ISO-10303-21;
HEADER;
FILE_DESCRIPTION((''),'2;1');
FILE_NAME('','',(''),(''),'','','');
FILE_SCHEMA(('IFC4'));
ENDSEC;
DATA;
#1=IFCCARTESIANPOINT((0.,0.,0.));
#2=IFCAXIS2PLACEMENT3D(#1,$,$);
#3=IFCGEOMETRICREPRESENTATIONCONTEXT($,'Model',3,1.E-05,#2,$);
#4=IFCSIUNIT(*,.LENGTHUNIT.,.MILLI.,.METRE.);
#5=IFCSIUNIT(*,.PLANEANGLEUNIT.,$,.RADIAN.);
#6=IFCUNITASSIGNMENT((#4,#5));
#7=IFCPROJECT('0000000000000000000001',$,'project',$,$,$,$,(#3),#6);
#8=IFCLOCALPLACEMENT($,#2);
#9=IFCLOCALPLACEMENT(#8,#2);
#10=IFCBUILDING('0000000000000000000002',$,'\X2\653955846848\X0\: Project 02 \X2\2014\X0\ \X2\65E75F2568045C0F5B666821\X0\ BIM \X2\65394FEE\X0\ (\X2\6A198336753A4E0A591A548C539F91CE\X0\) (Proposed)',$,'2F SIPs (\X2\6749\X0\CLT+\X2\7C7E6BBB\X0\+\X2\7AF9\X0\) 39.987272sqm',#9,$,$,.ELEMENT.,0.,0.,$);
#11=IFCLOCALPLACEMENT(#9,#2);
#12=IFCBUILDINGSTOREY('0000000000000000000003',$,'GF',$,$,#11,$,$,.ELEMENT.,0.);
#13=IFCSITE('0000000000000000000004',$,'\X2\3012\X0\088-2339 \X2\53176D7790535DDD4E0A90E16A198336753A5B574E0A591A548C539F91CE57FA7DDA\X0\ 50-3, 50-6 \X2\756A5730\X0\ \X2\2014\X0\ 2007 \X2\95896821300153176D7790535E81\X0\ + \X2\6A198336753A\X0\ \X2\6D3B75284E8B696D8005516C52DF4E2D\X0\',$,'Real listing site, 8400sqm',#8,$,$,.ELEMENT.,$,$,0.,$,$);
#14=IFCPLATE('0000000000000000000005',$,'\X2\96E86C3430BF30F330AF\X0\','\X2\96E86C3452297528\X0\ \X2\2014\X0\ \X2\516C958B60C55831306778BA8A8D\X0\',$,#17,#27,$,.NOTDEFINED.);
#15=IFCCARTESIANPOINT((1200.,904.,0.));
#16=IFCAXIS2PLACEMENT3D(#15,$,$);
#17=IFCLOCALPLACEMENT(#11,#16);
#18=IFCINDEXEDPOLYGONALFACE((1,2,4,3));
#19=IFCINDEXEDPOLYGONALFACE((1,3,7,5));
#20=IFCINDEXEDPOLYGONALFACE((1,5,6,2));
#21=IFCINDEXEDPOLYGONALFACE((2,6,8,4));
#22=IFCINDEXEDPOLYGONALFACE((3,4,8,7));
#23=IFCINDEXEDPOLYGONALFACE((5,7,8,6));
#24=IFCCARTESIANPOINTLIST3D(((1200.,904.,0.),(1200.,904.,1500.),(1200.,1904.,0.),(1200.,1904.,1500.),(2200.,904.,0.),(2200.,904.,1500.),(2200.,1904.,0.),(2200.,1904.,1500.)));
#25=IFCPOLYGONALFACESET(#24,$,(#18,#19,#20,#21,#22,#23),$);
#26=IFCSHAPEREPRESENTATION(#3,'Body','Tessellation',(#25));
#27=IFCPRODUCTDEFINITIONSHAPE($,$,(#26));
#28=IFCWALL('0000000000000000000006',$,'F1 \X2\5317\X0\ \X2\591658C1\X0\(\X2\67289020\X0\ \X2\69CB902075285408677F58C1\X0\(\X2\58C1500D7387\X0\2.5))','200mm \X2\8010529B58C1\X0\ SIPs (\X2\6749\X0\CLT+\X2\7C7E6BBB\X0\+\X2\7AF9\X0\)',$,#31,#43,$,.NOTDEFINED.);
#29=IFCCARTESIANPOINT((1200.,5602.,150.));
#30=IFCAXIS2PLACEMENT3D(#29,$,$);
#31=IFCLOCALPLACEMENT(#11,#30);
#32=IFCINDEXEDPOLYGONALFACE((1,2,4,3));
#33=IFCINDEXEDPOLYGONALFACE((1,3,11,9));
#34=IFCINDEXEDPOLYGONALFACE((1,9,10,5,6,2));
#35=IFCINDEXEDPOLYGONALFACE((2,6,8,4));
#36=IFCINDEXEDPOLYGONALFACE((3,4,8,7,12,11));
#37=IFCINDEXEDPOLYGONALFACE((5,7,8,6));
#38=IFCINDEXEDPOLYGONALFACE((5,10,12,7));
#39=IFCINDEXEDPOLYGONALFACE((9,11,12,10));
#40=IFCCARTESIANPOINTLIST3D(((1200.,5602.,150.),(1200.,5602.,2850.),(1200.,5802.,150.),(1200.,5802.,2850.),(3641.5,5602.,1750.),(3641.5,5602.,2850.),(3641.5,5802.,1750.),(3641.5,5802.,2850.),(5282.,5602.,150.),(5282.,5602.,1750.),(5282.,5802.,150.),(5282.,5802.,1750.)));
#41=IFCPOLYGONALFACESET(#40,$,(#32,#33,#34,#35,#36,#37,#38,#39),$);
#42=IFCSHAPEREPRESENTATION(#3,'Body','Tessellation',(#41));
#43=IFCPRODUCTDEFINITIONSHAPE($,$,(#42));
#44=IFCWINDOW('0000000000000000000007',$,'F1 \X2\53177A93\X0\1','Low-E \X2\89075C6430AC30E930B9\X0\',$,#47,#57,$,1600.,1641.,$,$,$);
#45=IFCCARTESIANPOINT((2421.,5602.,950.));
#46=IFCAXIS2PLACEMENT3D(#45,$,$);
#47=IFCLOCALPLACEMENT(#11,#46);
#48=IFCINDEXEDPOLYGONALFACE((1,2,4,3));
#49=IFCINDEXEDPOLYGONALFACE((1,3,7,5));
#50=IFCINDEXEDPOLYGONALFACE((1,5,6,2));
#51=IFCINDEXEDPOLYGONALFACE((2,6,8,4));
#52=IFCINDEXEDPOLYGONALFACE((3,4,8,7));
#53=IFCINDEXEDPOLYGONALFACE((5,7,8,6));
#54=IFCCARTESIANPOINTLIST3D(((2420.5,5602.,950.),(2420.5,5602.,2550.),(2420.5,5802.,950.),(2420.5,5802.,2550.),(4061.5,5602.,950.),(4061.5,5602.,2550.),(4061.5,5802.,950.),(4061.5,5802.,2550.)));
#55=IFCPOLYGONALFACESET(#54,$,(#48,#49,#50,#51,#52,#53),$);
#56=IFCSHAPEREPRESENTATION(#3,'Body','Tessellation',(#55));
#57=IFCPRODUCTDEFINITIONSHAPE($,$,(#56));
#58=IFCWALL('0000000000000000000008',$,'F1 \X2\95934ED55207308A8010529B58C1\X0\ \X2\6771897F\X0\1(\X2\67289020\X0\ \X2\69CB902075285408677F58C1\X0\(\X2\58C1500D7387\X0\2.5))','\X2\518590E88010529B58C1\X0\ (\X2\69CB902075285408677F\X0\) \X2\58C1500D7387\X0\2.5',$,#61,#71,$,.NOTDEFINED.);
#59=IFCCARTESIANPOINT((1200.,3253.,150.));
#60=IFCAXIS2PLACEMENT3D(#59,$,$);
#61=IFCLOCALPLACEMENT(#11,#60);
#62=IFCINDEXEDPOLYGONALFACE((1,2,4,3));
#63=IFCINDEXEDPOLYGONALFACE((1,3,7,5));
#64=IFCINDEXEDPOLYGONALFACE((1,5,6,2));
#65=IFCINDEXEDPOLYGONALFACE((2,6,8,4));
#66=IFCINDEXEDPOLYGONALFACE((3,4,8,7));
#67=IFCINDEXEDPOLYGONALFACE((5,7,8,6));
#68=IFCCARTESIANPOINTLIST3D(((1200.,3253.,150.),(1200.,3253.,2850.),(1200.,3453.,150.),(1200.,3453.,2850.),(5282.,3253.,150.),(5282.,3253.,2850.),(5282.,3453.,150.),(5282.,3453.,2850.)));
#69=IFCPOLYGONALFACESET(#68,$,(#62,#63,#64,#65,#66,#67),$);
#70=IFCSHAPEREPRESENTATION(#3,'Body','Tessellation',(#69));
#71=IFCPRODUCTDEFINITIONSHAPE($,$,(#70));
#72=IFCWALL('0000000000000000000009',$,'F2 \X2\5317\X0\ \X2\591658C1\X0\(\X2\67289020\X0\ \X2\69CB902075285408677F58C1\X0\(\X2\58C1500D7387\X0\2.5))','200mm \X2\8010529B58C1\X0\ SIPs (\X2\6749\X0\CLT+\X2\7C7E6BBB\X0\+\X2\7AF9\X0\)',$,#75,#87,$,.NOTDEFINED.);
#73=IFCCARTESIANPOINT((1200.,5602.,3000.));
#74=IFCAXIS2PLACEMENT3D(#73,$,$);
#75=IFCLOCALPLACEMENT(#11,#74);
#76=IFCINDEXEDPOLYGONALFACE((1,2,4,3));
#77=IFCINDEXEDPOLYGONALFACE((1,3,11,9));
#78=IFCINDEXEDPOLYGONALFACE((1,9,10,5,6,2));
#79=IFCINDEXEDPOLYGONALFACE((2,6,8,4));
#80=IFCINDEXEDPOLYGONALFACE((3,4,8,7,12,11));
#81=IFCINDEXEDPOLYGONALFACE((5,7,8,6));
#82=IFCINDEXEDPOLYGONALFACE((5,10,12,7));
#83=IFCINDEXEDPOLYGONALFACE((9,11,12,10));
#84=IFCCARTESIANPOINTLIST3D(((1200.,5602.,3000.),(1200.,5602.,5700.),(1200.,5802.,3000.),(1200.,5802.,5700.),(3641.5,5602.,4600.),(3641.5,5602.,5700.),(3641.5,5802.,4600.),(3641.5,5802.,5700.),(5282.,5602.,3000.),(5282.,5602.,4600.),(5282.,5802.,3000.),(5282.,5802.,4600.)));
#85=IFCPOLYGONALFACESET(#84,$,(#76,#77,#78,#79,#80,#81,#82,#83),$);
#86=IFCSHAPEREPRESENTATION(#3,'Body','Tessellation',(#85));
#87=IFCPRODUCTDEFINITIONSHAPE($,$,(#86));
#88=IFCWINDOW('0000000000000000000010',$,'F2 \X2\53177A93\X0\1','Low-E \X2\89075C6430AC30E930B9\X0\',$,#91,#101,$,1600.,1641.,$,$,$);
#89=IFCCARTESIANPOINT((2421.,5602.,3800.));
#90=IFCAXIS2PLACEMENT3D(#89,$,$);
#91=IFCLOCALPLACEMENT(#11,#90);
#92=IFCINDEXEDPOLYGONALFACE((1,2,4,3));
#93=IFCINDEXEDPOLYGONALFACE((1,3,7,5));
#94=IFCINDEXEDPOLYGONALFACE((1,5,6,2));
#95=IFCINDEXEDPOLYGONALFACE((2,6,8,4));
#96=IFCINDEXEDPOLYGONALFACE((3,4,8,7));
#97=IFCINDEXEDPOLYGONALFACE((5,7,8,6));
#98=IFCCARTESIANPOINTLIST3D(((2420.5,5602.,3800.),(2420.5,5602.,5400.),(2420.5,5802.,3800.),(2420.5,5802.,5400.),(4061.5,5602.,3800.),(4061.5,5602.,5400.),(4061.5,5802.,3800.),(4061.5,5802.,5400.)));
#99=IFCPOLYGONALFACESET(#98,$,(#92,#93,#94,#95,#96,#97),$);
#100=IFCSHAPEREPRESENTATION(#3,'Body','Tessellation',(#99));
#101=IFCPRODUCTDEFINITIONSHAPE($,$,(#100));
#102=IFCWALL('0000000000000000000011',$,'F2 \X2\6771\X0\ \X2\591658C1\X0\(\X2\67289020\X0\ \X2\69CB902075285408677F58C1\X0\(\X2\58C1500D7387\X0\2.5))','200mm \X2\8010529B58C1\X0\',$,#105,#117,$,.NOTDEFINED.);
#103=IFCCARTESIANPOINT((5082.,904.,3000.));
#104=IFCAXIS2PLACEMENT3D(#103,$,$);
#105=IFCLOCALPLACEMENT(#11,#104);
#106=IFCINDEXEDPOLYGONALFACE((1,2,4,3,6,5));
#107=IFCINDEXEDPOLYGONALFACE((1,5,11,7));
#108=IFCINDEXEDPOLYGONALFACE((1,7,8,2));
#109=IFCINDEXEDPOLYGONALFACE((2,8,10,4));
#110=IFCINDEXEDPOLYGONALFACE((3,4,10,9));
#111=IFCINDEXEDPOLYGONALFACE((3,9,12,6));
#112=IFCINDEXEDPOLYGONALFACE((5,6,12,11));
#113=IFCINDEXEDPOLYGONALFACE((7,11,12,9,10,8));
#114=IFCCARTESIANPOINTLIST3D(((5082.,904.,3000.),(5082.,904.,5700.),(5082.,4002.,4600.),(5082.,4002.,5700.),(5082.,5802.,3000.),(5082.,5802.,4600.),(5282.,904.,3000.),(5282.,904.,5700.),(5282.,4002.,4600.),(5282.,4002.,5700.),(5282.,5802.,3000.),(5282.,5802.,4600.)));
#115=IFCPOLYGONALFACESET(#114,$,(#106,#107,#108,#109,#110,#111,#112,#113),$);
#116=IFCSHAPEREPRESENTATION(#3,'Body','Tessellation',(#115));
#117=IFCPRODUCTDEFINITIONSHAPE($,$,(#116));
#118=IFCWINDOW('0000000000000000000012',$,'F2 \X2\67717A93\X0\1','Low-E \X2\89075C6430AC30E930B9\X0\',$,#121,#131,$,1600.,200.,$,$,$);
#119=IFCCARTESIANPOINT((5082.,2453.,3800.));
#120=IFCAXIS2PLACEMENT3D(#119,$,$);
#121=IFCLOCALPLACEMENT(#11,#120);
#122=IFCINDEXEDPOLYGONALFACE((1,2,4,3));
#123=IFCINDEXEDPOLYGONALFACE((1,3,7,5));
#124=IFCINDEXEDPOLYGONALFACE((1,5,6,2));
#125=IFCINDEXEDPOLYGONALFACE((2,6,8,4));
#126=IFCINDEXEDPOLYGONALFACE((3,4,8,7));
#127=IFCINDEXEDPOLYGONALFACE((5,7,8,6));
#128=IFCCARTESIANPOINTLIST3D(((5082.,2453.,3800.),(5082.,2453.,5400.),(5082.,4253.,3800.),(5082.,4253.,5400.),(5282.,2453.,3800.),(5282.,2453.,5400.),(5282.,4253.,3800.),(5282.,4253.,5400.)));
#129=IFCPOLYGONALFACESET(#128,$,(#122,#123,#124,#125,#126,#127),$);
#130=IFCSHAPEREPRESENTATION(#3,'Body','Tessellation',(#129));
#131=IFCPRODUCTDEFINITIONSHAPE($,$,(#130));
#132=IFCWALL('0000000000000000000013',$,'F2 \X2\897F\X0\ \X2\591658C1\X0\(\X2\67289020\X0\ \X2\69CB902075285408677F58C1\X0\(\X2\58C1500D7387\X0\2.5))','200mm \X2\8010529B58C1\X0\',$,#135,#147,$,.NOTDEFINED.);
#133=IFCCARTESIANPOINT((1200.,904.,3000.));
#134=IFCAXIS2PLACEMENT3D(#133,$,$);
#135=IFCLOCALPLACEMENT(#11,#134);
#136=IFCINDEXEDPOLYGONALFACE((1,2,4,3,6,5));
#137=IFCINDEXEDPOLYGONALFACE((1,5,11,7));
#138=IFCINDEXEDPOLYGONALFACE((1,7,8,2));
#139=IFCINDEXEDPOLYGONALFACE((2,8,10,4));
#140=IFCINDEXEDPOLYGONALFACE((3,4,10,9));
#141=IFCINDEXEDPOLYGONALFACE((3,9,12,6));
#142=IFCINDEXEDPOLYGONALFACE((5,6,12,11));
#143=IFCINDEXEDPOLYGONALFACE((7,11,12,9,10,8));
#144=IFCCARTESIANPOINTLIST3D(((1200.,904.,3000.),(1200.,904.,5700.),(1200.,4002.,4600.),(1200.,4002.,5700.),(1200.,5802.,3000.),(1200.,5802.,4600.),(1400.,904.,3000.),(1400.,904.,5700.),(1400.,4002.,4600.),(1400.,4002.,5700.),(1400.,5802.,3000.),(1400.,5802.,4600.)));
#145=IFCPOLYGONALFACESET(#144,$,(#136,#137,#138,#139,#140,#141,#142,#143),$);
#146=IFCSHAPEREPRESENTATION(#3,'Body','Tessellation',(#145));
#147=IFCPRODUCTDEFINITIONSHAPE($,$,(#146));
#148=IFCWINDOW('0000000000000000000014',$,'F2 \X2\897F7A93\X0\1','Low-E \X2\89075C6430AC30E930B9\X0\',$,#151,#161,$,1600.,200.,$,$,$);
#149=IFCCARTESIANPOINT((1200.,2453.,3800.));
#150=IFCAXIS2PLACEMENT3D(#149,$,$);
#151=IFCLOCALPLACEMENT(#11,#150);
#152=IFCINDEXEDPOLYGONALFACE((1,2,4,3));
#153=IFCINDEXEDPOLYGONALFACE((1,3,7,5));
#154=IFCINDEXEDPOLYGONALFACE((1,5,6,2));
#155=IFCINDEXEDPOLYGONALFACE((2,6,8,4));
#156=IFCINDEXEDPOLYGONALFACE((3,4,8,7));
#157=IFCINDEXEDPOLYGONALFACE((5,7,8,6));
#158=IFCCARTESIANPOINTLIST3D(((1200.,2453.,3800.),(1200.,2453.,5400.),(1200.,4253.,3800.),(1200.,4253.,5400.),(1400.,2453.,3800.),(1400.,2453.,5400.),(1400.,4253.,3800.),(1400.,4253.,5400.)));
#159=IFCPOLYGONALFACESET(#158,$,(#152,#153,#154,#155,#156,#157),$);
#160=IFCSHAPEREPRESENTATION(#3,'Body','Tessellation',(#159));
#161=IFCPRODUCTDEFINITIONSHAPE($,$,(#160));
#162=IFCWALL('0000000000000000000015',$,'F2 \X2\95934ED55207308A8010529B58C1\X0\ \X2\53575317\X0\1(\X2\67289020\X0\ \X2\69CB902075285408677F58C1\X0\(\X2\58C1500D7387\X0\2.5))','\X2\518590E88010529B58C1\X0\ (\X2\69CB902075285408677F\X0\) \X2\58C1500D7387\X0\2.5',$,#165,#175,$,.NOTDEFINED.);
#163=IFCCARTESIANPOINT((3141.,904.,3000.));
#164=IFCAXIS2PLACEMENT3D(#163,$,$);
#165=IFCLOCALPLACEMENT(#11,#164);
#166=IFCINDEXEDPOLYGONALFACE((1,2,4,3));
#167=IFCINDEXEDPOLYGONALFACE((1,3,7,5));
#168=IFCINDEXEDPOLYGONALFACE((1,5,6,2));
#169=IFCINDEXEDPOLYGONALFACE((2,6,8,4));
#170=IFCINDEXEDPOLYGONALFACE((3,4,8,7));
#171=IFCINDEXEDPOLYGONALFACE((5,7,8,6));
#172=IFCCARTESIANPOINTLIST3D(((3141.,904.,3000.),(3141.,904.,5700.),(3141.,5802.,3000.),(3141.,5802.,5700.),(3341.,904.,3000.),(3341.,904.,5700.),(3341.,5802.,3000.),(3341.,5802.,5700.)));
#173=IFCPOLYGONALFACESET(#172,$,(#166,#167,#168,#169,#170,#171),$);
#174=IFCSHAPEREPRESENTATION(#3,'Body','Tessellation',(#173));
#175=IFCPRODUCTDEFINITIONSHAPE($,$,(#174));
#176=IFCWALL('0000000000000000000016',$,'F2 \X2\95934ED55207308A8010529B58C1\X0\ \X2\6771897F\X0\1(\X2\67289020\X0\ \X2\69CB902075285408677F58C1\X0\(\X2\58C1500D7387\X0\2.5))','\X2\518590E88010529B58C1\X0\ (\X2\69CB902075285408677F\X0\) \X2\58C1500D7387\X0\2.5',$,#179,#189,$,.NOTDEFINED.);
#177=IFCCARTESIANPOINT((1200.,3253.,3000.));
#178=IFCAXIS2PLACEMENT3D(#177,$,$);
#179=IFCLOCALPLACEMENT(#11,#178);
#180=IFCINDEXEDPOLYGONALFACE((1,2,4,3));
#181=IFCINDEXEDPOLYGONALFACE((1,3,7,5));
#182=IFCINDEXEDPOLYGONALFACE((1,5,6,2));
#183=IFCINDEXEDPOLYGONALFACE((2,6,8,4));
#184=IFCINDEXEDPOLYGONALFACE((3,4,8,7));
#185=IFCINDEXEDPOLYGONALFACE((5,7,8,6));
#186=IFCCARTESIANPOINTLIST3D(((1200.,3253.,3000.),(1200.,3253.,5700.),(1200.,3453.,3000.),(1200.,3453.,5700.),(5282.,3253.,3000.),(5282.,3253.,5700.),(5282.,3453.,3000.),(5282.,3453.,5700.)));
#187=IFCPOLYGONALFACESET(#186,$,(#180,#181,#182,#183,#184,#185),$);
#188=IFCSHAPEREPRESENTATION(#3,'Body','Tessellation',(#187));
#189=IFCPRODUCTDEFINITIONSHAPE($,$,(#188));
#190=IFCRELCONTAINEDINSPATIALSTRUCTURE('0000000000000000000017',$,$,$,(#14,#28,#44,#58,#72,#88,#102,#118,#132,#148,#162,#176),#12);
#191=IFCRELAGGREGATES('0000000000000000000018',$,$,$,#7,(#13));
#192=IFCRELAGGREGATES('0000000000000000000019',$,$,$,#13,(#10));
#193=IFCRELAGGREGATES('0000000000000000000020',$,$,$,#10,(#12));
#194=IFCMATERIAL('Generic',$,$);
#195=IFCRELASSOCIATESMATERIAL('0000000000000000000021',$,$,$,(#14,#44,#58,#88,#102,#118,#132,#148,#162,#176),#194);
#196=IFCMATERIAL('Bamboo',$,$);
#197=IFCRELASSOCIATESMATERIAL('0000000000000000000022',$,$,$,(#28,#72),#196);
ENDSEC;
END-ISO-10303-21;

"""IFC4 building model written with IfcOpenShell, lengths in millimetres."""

from ifc_helpers import new_model, si_unit, frame, frame_2d, origin, place, context, project, spatial, rectangle, extrude, material, element, fill, save


model = new_model("IFC4")

# Units and contexts
model_context = context("Model", 3, precision=1e-05, world=origin())
ifc_project = project(units=[si_unit("LENGTHUNIT", "METRE", prefix="MILLI"), si_unit("PLANEANGLEUNIT", "RADIAN")], contexts=[model_context])

# Site, building, storey
site_placement = place(None, origin())
site = spatial("IfcSite", under=ifc_project, at=site_placement, Name="〒088-2339 北海道川上郡標茶町字上多和原野基線 50-3, 50-6 番地 — 2007 閉校、北海道庁 + 標茶町 活用事業者公募中", ObjectType="Real listing site, 8400sqm", CompositionType="ELEMENT", RefElevation=0.0)
building_placement = place(site_placement, origin())
building = spatial("IfcBuilding", under=site, at=building_placement, Name="改善案: Project 02 — 旧弥栄小学校 BIM 改修 (標茶町上多和原野) (Proposed)", ObjectType="2F SIPs (杉CLT+籾殻+竹) 39.987272sqm", CompositionType="ELEMENT", ElevationOfRefHeight=0.0, ElevationOfTerrain=0.0)
storey_placement = place(building_placement, origin())
storey = spatial("IfcBuildingStorey", under=building, at=storey_placement, Name="GF", CompositionType="ELEMENT", Elevation=0.0)

# Plate
ifc_material_1 = material(Name="Generic")
plate_placement = place(storey_placement, frame((1200.0, 904.0, 0.0)))
element("IfcPlate", 1, at=plate_placement, inside=storey, material=ifc_material_1, Name="雨水タンク", Description="雨水利用 — 公開情報で確認", PredefinedType="NOTDEFINED", context=model_context, shape_type="SweptSolid", body=[
    extrude(rectangle(XDim=1000.0, YDim=1000.0, at=frame_2d((500.0, 500.0))), frame((1200.0, 904.0, 0.0)), (0.0, 0.0, 1.0), 1500.0),
])

# Wall, opening, window
ifc_material_2 = material(Name="Bamboo")
wall_1_placement = place(storey_placement, frame((1200.0, 5602.0, 150.0)))
wall_1 = element("IfcWall", 2, at=wall_1_placement, inside=storey, material=ifc_material_2, Name="F1 北 外壁(木造 構造用合板壁(壁倍率2.5))", Description="200mm 耐力壁 SIPs (杉CLT+籾殻+竹)", PredefinedType="NOTDEFINED", context=model_context, shape_type="SweptSolid", body=[
    extrude(rectangle(XDim=4082.0, YDim=200.0, at=frame_2d((2041.0, 100.0))), frame((1200.0, 5602.0, 150.0)), (0.0, 0.0, 1.0), 2700.0),
])
opening_1_placement = place(storey_placement, frame((2421.0, 5602.0, 950.0)))
opening_1 = element("IfcOpeningElement", 3, at=opening_1_placement, cuts=wall_1, PredefinedType="NOTDEFINED", context=model_context, shape_type="SweptSolid", body=[
    extrude(rectangle(XDim=1641.0, YDim=200.0, at=frame_2d((820.0, 100.0))), frame((2421.0, 5602.0, 950.0)), (0.0, 0.0, 1.0), 1600.0),
])
window_1_placement = place(storey_placement, frame((2421.0, 5602.0, 950.0)))
window_1 = element("IfcWindow", 4, at=window_1_placement, inside=storey, material=ifc_material_1, Name="F1 北窓1", Description="Low-E 複層ガラス", OverallHeight=1600.0, OverallWidth=1641.0, context=model_context, shape_type="SweptSolid", body=[
    extrude(rectangle(XDim=1641.0, YDim=200.0, at=frame_2d((820.0, 100.0))), frame((2421.0, 5602.0, 950.0)), (0.0, 0.0, 1.0), 1600.0),
])
fill(opening_1, window_1)

# Wall
wall_2_placement = place(storey_placement, frame((1200.0, 3253.0, 150.0)))
element("IfcWall", 5, at=wall_2_placement, inside=storey, material=ifc_material_1, Name="F1 間仕切り耐力壁 東西1(木造 構造用合板壁(壁倍率2.5))", Description="内部耐力壁 (構造用合板) 壁倍率2.5", PredefinedType="NOTDEFINED", context=model_context, shape_type="SweptSolid", body=[
    extrude(rectangle(XDim=4082.0, YDim=200.0, at=frame_2d((2041.0, 100.0))), frame((1200.0, 3253.0, 150.0)), (0.0, 0.0, 1.0), 2700.0),
])

# Walls, openings, windows
wall_3_placement = place(storey_placement, frame((1200.0, 5602.0, 3000.0)))
wall_3 = element("IfcWall", 6, at=wall_3_placement, inside=storey, material=ifc_material_2, Name="F2 北 外壁(木造 構造用合板壁(壁倍率2.5))", Description="200mm 耐力壁 SIPs (杉CLT+籾殻+竹)", PredefinedType="NOTDEFINED", context=model_context, shape_type="SweptSolid", body=[
    extrude(rectangle(XDim=4082.0, YDim=200.0, at=frame_2d((2041.0, 100.0))), frame((1200.0, 5602.0, 3000.0)), (0.0, 0.0, 1.0), 2700.0),
])
opening_2_placement = place(storey_placement, frame((2421.0, 5602.0, 3800.0)))
opening_2 = element("IfcOpeningElement", 7, at=opening_2_placement, cuts=wall_3, PredefinedType="NOTDEFINED", context=model_context, shape_type="SweptSolid", body=[
    extrude(rectangle(XDim=1641.0, YDim=200.0, at=frame_2d((820.0, 100.0))), frame((2421.0, 5602.0, 3800.0)), (0.0, 0.0, 1.0), 1600.0),
])
window_2_placement = place(storey_placement, frame((2421.0, 5602.0, 3800.0)))
window_2 = element("IfcWindow", 8, at=window_2_placement, inside=storey, material=ifc_material_1, Name="F2 北窓1", Description="Low-E 複層ガラス", OverallHeight=1600.0, OverallWidth=1641.0, context=model_context, shape_type="SweptSolid", body=[
    extrude(rectangle(XDim=1641.0, YDim=200.0, at=frame_2d((820.0, 100.0))), frame((2421.0, 5602.0, 3800.0)), (0.0, 0.0, 1.0), 1600.0),
])
fill(opening_2, window_2)
wall_4_placement = place(storey_placement, frame((5082.0, 904.0, 3000.0)))
wall_4 = element("IfcWall", 9, at=wall_4_placement, inside=storey, material=ifc_material_1, Name="F2 東 外壁(木造 構造用合板壁(壁倍率2.5))", Description="200mm 耐力壁", PredefinedType="NOTDEFINED", context=model_context, shape_type="SweptSolid", body=[
    extrude(rectangle(XDim=200.0, YDim=4898.0, at=frame_2d((100.0, 2449.0))), frame((5082.0, 904.0, 3000.0)), (0.0, 0.0, 1.0), 2700.0),
])
opening_3_placement = place(storey_placement, frame((5082.0, 2453.0, 3800.0)))
opening_3 = element("IfcOpeningElement", 10, at=opening_3_placement, cuts=wall_4, PredefinedType="NOTDEFINED", context=model_context, shape_type="SweptSolid", body=[
    extrude(rectangle(XDim=200.0, YDim=1800.0, at=frame_2d((100.0, 900.0))), frame((5082.0, 2453.0, 3800.0)), (0.0, 0.0, 1.0), 1600.0),
])
window_3_placement = place(storey_placement, frame((5082.0, 2453.0, 3800.0)))
window_3 = element("IfcWindow", 11, at=window_3_placement, inside=storey, material=ifc_material_1, Name="F2 東窓1", Description="Low-E 複層ガラス", OverallHeight=1600.0, OverallWidth=200.0, context=model_context, shape_type="SweptSolid", body=[
    extrude(rectangle(XDim=200.0, YDim=1800.0, at=frame_2d((100.0, 900.0))), frame((5082.0, 2453.0, 3800.0)), (0.0, 0.0, 1.0), 1600.0),
])
fill(opening_3, window_3)
wall_5_placement = place(storey_placement, frame((1200.0, 904.0, 3000.0)))
wall_5 = element("IfcWall", 12, at=wall_5_placement, inside=storey, material=ifc_material_1, Name="F2 西 外壁(木造 構造用合板壁(壁倍率2.5))", Description="200mm 耐力壁", PredefinedType="NOTDEFINED", context=model_context, shape_type="SweptSolid", body=[
    extrude(rectangle(XDim=200.0, YDim=4898.0, at=frame_2d((100.0, 2449.0))), frame((1200.0, 904.0, 3000.0)), (0.0, 0.0, 1.0), 2700.0),
])
opening_4_placement = place(storey_placement, frame((1200.0, 2453.0, 3800.0)))
opening_4 = element("IfcOpeningElement", 13, at=opening_4_placement, cuts=wall_5, PredefinedType="NOTDEFINED", context=model_context, shape_type="SweptSolid", body=[
    extrude(rectangle(XDim=200.0, YDim=1800.0, at=frame_2d((100.0, 900.0))), frame((1200.0, 2453.0, 3800.0)), (0.0, 0.0, 1.0), 1600.0),
])
window_4_placement = place(storey_placement, frame((1200.0, 2453.0, 3800.0)))
window_4 = element("IfcWindow", 14, at=window_4_placement, inside=storey, material=ifc_material_1, Name="F2 西窓1", Description="Low-E 複層ガラス", OverallHeight=1600.0, OverallWidth=200.0, context=model_context, shape_type="SweptSolid", body=[
    extrude(rectangle(XDim=200.0, YDim=1800.0, at=frame_2d((100.0, 900.0))), frame((1200.0, 2453.0, 3800.0)), (0.0, 0.0, 1.0), 1600.0),
])
fill(opening_4, window_4)

# Walls
wall_6_placement = place(storey_placement, frame((3141.0, 904.0, 3000.0)))
element("IfcWall", 15, at=wall_6_placement, inside=storey, material=ifc_material_1, Name="F2 間仕切り耐力壁 南北1(木造 構造用合板壁(壁倍率2.5))", Description="内部耐力壁 (構造用合板) 壁倍率2.5", PredefinedType="NOTDEFINED", context=model_context, shape_type="SweptSolid", body=[
    extrude(rectangle(XDim=200.0, YDim=4898.0, at=frame_2d((100.0, 2449.0))), frame((3141.0, 904.0, 3000.0)), (0.0, 0.0, 1.0), 2700.0),
])
wall_7_placement = place(storey_placement, frame((1200.0, 3253.0, 3000.0)))
element("IfcWall", 16, at=wall_7_placement, inside=storey, material=ifc_material_1, Name="F2 間仕切り耐力壁 東西1(木造 構造用合板壁(壁倍率2.5))", Description="内部耐力壁 (構造用合板) 壁倍率2.5", PredefinedType="NOTDEFINED", context=model_context, shape_type="SweptSolid", body=[
    extrude(rectangle(XDim=4082.0, YDim=200.0, at=frame_2d((2041.0, 100.0))), frame((1200.0, 3253.0, 3000.0)), (0.0, 0.0, 1.0), 2700.0),
])

save(model, "model.ifc")
